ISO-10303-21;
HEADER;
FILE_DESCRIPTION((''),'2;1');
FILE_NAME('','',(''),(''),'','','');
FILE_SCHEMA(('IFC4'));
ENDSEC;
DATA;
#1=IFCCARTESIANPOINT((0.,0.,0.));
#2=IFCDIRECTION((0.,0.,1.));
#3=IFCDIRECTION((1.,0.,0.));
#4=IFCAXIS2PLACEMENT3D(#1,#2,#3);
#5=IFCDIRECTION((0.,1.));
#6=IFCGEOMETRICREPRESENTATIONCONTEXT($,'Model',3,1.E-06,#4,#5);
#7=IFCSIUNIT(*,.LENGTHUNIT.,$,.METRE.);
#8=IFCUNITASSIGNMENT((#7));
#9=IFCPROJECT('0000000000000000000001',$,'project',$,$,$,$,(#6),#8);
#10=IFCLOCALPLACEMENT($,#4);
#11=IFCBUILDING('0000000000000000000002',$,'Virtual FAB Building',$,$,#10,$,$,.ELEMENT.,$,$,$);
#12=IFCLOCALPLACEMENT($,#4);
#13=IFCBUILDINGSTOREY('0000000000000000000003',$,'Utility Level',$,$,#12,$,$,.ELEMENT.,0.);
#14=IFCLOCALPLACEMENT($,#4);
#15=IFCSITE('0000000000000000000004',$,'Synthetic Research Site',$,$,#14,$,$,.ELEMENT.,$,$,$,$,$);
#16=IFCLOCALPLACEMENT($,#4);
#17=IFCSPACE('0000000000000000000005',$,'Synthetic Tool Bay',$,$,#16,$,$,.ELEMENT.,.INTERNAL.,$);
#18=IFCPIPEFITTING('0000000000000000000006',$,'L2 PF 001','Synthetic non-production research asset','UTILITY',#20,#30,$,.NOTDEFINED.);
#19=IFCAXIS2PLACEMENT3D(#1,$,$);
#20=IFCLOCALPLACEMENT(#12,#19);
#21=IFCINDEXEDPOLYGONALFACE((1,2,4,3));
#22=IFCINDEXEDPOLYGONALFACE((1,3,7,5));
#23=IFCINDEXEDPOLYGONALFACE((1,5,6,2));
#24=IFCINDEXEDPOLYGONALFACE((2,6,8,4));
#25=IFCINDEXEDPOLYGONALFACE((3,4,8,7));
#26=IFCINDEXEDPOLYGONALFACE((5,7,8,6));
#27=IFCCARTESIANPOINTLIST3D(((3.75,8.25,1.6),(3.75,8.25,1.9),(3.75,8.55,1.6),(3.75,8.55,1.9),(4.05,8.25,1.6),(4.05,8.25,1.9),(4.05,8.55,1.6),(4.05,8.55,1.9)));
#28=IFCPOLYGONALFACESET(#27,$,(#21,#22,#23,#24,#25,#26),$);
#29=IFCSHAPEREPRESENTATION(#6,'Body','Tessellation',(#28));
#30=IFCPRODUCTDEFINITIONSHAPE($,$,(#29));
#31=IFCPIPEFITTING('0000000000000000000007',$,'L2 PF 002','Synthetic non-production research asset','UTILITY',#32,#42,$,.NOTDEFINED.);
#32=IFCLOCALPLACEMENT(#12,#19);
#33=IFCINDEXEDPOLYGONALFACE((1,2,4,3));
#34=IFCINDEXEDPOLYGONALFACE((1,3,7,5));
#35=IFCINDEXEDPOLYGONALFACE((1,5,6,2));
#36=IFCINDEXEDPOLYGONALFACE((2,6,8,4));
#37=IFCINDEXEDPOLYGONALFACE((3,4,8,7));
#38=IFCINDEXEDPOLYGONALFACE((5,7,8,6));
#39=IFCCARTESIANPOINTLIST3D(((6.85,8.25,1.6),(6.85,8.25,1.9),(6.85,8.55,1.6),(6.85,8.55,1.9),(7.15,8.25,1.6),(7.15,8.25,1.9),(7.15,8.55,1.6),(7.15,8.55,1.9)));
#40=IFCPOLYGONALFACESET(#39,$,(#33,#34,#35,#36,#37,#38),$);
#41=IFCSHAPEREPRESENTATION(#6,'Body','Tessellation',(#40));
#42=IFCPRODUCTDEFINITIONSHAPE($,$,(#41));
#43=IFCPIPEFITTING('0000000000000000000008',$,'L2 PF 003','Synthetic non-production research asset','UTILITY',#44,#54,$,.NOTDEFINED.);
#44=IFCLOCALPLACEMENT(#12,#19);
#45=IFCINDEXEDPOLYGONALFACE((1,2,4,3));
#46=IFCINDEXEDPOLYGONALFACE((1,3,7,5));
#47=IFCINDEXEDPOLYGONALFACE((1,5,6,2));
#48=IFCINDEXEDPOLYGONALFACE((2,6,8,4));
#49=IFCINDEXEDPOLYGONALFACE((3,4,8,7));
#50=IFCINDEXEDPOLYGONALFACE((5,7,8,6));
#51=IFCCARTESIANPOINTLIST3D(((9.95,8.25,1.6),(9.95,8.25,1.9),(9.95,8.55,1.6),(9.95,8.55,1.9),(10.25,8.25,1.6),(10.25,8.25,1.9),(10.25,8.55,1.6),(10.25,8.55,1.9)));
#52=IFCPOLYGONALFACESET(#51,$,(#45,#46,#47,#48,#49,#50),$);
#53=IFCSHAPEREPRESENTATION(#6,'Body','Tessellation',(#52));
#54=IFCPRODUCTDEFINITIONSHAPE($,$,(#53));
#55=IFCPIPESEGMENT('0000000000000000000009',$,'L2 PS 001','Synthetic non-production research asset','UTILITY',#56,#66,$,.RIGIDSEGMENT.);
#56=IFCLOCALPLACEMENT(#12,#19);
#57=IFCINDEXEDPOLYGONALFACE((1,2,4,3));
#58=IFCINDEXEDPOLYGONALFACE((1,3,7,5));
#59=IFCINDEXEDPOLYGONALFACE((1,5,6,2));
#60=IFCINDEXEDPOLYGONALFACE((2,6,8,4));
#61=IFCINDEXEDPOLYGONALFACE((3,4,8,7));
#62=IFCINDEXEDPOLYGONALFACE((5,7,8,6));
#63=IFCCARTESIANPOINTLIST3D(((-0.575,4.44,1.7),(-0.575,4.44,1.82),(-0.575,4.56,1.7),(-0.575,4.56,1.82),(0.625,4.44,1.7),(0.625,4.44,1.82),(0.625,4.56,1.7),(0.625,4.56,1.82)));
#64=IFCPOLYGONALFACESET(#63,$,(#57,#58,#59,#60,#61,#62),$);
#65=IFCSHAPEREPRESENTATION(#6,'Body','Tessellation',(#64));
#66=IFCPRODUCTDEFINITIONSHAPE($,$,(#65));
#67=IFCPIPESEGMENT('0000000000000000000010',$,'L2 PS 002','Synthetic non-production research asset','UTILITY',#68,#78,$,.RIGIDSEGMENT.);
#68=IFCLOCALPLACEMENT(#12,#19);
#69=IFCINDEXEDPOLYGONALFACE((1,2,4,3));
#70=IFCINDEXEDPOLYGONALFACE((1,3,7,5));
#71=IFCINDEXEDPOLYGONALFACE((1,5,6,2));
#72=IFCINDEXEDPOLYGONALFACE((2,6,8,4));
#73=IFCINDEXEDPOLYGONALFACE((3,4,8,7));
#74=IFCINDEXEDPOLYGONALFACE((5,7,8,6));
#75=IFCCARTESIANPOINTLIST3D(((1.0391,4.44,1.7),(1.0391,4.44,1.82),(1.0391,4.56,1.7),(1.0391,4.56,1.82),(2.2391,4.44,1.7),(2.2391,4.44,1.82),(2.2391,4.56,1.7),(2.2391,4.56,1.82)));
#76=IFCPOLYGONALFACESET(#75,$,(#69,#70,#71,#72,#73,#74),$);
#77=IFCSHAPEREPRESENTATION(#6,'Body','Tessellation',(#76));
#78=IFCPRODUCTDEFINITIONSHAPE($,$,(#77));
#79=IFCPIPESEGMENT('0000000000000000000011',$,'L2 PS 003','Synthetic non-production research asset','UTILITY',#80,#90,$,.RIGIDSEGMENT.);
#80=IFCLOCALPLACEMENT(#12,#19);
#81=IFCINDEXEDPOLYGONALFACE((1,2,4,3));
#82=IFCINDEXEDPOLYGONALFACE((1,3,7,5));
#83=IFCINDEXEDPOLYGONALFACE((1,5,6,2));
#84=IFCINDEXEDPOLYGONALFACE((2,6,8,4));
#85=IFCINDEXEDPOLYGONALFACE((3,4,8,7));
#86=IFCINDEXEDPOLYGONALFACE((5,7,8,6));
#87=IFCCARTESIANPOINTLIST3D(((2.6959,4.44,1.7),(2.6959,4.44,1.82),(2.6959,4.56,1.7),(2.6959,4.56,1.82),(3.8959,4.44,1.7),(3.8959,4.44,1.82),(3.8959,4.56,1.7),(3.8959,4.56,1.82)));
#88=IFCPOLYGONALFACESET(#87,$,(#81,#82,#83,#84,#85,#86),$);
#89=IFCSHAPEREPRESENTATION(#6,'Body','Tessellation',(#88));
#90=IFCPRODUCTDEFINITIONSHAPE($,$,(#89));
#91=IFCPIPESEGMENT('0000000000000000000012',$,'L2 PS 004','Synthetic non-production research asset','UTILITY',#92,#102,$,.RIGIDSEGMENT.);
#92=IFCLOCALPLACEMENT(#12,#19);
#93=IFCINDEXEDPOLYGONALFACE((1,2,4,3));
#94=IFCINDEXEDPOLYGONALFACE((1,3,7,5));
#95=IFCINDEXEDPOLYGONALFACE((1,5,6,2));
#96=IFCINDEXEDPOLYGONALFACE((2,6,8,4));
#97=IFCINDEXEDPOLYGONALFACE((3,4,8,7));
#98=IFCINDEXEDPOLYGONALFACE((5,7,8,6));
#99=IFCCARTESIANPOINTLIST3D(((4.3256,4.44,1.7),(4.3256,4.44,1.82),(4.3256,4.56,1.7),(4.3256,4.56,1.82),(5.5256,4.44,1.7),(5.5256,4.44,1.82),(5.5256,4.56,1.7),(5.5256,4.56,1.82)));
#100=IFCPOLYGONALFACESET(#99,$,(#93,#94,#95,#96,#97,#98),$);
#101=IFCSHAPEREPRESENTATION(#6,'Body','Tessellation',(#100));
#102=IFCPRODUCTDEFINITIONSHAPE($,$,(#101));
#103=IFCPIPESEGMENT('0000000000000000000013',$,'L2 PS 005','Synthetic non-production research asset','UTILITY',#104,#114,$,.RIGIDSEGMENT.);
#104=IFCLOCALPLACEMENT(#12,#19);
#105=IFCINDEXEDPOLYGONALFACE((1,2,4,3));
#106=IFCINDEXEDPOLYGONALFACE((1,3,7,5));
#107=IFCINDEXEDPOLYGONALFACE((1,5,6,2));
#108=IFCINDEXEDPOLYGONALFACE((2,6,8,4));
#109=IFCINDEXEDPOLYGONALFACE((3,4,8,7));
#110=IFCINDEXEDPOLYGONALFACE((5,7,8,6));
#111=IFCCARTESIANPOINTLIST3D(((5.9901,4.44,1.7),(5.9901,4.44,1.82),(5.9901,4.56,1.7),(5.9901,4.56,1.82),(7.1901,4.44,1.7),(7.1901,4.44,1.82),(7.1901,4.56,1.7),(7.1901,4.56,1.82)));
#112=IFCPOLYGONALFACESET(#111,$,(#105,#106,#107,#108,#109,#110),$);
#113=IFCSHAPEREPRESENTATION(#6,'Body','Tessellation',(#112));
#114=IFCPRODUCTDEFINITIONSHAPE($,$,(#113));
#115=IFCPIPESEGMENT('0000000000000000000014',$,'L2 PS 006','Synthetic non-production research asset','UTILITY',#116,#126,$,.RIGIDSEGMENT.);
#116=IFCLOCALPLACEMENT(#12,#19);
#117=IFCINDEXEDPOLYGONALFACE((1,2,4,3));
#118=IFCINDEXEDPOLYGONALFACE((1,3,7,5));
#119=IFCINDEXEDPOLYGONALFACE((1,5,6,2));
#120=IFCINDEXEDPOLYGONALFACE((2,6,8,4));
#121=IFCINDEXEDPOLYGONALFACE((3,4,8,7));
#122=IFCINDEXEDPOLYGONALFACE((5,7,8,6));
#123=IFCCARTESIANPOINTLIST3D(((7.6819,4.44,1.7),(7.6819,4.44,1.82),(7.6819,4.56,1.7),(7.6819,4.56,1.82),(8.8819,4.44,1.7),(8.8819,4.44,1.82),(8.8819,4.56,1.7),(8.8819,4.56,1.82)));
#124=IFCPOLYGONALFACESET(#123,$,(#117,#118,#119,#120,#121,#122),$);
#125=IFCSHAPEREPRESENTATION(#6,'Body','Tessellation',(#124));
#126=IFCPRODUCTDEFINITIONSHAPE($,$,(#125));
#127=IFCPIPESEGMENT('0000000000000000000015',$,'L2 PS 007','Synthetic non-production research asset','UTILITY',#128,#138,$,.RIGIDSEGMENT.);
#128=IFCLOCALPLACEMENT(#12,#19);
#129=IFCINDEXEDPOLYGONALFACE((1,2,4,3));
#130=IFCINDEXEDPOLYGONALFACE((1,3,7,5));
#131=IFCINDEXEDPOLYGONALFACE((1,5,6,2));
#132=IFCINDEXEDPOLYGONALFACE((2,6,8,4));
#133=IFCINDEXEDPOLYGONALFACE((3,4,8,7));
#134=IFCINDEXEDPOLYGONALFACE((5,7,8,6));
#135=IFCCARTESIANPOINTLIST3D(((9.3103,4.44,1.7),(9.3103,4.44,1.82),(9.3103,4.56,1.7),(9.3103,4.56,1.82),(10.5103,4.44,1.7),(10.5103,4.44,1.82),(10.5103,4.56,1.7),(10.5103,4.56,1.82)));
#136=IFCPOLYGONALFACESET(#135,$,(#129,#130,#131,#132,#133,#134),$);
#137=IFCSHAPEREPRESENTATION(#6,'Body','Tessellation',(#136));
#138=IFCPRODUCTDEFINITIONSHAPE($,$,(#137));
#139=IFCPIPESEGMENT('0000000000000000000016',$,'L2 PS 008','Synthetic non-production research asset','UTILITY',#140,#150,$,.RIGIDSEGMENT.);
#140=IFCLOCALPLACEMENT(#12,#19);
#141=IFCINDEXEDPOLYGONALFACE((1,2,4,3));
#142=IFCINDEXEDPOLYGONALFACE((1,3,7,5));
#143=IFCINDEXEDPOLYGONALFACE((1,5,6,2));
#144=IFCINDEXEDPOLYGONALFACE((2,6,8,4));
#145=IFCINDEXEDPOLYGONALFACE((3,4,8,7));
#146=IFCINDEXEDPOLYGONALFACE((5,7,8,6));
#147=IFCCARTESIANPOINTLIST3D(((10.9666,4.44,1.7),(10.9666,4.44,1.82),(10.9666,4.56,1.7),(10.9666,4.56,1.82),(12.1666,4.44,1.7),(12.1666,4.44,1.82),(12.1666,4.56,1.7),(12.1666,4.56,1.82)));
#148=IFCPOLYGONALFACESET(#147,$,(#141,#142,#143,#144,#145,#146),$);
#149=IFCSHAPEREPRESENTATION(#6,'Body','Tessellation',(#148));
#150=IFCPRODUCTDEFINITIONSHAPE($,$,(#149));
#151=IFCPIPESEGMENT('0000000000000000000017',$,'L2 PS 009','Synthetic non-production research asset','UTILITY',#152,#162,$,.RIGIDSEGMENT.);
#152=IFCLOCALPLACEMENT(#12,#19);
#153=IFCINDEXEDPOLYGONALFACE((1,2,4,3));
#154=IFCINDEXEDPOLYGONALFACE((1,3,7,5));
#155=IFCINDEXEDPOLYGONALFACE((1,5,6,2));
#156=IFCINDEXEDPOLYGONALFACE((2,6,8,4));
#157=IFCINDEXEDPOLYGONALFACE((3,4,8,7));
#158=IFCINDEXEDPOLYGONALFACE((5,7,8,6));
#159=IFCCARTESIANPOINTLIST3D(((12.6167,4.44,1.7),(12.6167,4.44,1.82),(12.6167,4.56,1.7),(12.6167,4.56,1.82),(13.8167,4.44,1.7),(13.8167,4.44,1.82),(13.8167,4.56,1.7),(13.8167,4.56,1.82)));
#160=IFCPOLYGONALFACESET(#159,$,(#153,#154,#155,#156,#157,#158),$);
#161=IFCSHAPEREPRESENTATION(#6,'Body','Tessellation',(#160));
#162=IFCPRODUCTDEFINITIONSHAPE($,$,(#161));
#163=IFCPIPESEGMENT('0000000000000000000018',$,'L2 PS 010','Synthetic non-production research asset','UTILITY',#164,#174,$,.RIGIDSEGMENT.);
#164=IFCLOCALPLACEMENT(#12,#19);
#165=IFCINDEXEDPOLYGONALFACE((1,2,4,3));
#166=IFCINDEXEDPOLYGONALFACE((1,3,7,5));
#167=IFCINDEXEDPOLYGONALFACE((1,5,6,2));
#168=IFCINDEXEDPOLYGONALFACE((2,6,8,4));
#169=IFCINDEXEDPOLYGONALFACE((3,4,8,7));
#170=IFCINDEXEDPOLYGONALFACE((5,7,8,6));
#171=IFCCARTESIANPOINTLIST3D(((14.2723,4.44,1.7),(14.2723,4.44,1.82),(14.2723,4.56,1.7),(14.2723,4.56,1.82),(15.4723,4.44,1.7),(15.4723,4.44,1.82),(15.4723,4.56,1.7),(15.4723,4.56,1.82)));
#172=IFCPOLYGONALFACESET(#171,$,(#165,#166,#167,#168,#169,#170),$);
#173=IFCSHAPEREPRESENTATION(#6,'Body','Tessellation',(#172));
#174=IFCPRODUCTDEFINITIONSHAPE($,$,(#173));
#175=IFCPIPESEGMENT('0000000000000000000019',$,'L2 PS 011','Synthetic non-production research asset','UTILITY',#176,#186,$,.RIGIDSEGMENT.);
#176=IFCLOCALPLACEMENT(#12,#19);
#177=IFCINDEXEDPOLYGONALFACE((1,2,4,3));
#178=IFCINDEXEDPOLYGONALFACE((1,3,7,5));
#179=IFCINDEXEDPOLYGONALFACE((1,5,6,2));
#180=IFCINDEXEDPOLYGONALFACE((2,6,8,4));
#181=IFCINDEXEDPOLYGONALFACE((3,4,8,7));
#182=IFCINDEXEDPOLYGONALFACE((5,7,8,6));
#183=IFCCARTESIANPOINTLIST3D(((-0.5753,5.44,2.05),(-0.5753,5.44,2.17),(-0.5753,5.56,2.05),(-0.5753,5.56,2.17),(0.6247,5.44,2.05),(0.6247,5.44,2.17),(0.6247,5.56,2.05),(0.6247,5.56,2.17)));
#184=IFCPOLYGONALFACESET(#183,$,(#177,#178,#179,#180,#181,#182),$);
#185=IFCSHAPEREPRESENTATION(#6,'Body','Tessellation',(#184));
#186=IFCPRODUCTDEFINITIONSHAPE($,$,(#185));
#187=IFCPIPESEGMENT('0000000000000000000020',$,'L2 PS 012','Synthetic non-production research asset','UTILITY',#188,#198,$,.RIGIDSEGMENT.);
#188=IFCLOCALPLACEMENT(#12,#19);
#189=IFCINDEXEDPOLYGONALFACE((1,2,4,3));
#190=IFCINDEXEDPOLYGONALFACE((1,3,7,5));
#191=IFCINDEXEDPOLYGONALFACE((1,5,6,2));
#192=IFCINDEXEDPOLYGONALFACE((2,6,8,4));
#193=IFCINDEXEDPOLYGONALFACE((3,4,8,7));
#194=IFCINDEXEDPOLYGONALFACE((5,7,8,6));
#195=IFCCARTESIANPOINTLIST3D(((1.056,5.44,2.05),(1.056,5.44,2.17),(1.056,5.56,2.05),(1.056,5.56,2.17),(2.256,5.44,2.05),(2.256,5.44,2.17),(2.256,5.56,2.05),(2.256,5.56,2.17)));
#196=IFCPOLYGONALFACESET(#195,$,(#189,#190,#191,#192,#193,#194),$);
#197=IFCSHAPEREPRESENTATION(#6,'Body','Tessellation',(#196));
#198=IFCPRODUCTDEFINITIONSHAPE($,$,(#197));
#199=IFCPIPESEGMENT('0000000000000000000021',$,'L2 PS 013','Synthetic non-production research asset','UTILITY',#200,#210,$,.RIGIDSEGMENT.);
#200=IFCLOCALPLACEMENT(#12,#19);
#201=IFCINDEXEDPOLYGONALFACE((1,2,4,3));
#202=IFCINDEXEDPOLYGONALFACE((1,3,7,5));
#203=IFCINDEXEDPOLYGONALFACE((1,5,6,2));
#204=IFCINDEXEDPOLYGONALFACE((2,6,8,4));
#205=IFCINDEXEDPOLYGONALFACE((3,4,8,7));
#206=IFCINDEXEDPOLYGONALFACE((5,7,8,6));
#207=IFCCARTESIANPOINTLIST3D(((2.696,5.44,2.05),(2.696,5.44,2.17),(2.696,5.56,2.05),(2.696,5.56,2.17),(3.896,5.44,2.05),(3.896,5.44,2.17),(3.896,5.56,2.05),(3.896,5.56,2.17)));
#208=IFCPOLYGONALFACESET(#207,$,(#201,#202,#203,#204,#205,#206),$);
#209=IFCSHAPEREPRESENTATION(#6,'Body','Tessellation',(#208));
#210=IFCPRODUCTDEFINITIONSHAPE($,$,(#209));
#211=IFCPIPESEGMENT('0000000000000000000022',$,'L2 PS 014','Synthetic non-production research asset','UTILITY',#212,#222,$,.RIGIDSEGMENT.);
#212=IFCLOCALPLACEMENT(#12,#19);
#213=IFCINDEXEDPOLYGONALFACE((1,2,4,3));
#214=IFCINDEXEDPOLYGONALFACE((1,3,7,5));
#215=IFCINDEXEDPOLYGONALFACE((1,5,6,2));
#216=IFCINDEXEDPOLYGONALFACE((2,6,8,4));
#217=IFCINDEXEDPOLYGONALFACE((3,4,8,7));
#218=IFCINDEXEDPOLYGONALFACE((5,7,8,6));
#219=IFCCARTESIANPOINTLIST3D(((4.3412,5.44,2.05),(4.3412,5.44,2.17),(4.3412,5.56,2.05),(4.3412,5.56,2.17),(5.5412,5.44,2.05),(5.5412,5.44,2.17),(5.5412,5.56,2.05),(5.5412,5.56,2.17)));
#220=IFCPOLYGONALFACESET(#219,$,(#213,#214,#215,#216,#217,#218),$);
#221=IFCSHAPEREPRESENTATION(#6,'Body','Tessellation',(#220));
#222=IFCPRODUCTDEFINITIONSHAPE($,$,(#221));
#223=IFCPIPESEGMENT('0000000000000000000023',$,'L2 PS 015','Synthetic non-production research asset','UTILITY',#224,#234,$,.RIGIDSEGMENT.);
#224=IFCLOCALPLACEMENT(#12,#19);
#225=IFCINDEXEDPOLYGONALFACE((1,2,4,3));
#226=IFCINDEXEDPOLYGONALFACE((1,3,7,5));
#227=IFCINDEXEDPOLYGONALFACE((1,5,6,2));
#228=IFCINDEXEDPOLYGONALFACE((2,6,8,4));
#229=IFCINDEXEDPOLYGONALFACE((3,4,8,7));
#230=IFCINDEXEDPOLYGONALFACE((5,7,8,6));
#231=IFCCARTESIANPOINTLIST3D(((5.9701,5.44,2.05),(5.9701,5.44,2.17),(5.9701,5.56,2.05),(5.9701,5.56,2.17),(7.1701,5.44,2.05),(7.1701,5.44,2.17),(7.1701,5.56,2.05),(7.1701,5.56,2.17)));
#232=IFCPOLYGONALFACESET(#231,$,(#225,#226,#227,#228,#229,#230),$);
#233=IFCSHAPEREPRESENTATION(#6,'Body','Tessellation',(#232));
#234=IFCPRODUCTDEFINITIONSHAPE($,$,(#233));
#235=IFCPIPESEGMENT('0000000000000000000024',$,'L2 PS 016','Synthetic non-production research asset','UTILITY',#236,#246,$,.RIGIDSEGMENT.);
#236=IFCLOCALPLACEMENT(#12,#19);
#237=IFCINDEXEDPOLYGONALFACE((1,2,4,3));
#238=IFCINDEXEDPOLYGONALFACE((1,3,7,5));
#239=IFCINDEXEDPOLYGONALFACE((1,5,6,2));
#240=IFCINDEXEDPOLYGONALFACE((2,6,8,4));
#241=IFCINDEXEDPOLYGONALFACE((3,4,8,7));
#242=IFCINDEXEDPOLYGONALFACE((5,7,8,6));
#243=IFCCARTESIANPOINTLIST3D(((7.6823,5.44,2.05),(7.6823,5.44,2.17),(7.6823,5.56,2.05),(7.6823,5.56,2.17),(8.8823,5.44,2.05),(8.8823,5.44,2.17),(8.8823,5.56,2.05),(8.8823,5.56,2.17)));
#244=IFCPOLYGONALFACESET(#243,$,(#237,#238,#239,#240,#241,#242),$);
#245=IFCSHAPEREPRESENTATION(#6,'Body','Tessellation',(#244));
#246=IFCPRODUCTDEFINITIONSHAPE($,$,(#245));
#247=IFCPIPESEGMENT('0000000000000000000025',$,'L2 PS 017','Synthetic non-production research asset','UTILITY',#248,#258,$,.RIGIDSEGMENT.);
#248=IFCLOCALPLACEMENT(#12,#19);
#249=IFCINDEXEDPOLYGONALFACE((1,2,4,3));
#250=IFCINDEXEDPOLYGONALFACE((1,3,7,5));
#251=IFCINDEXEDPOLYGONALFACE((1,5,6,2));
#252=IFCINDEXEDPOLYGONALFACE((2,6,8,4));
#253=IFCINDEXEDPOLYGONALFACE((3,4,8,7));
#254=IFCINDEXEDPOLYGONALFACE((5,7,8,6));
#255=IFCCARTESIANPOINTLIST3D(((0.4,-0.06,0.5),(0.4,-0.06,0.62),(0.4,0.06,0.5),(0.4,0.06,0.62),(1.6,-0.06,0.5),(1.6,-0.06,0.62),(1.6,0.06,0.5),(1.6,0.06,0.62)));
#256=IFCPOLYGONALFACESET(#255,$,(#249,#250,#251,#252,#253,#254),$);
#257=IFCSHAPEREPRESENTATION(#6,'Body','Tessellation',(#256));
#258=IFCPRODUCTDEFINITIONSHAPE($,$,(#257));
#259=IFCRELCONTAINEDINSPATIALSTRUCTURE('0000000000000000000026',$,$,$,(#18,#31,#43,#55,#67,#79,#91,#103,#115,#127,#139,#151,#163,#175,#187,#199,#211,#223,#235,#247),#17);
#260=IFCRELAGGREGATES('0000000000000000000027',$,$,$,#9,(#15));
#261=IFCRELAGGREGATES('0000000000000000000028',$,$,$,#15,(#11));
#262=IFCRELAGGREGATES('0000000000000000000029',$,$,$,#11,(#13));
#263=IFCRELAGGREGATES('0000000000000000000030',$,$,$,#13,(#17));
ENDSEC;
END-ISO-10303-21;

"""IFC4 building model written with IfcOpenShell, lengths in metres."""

from ifc_helpers import new_model, si_unit, direction, frame, origin_with_axes, origin_2d_with_axis, place, context, project, spatial, rectangle, extrude, element, save


model = new_model("IFC4")

# Units and contexts
model_context = context("Model", 3, precision=1e-06, world=origin_with_axes(), true_north=direction((0.0, 1.0)))
ifc_project = project(units=[si_unit("LENGTHUNIT", "METRE")], contexts=[model_context])

# Site, building, storey, space
site_placement = place(None, origin_with_axes())
site = spatial("IfcSite", under=ifc_project, at=site_placement, Name="Synthetic Research Site", CompositionType="ELEMENT")
building_placement = place(None, origin_with_axes())
building = spatial("IfcBuilding", under=site, at=building_placement, Name="Virtual FAB Building", CompositionType="ELEMENT")
storey_placement = place(None, origin_with_axes())
storey = spatial("IfcBuildingStorey", under=building, at=storey_placement, Name="Utility Level", CompositionType="ELEMENT", Elevation=0.0)
space_placement = place(None, origin_with_axes())
space = spatial("IfcSpace", under=storey, at=space_placement, Name="Synthetic Tool Bay", CompositionType="ELEMENT", PredefinedType="INTERNAL")

# Pipe fittings
for number, where, z_axis, x_axis, name in (
    (1, (3.9, 8.4, 1.6), (0.0, 0.0, 1.0), (1.0, 0.0, 0.0), "L2 PF 001"),
    (2, (7.0, 8.4, 1.6), (0.0, 0.0, 1.0), (1.0, 0.0, 0.0), "L2 PF 002"),
    (3, (10.1, 8.4, 1.6), (0.0, 0.0, 1.0), (1.0, 0.0, 0.0), "L2 PF 003"),
):
    element("IfcPipeFitting", number, at=place(None, frame(where, z_axis=z_axis, x_axis=x_axis)), inside=space, Name=name, Description="Synthetic non-production research asset", ObjectType="UTILITY", PredefinedType="NOTDEFINED", context=model_context, shape_type="SweptSolid", body=[
        extrude(rectangle(XDim=0.3, YDim=0.3, at=origin_2d_with_axis()), origin_with_axes(), (0.0, 0.0, 1.0), 0.3),
    ])

# Pipe segments
for number, where, z_axis, x_axis, name in (
    (4, (0.025, 4.5, 1.7), (0.0, 0.0, 1.0), (1.0, 0.0, 0.0), "L2 PS 001"),
    (5, (1.6391, 4.5, 1.7), (0.0, 0.0, 1.0), (1.0, 0.0, 0.0), "L2 PS 002"),
    (6, (3.2959, 4.5, 1.7), (0.0, 0.0, 1.0), (1.0, 0.0, 0.0), "L2 PS 003"),
    (7, (4.9256, 4.5, 1.7), (0.0, 0.0, 1.0), (1.0, 0.0, 0.0), "L2 PS 004"),
    (8, (6.5901, 4.5, 1.7), (0.0, 0.0, 1.0), (1.0, 0.0, 0.0), "L2 PS 005"),
    (9, (8.2819, 4.5, 1.7), (0.0, 0.0, 1.0), (1.0, 0.0, 0.0), "L2 PS 006"),
    (10, (9.9103, 4.5, 1.7), (0.0, 0.0, 1.0), (1.0, 0.0, 0.0), "L2 PS 007"),
    (11, (11.5666, 4.5, 1.7), (0.0, 0.0, 1.0), (1.0, 0.0, 0.0), "L2 PS 008"),
    (12, (13.2167, 4.5, 1.7), (0.0, 0.0, 1.0), (1.0, 0.0, 0.0), "L2 PS 009"),
    (13, (14.8723, 4.5, 1.7), (0.0, 0.0, 1.0), (1.0, 0.0, 0.0), "L2 PS 010"),
    (14, (0.0247, 5.5, 2.05), (0.0, 0.0, 1.0), (1.0, 0.0, 0.0), "L2 PS 011"),
    (15, (1.656, 5.5, 2.05), (0.0, 0.0, 1.0), (1.0, 0.0, 0.0), "L2 PS 012"),
    (16, (3.296, 5.5, 2.05), (0.0, 0.0, 1.0), (1.0, 0.0, 0.0), "L2 PS 013"),
    (17, (4.9412, 5.5, 2.05), (0.0, 0.0, 1.0), (1.0, 0.0, 0.0), "L2 PS 014"),
    (18, (6.5701, 5.5, 2.05), (0.0, 0.0, 1.0), (1.0, 0.0, 0.0), "L2 PS 015"),
    (19, (8.2823, 5.5, 2.05), (0.0, 0.0, 1.0), (1.0, 0.0, 0.0), "L2 PS 016"),
    (20, (1.0, 0.0, 0.5), (0.0, 0.0, 1.0), (1.0, 0.0, 0.0), "L2 PS 017"),
):
    element("IfcPipeSegment", number, at=place(None, frame(where, z_axis=z_axis, x_axis=x_axis)), inside=space, Name=name, Description="Synthetic non-production research asset", ObjectType="UTILITY", PredefinedType="RIGIDSEGMENT", context=model_context, shape_type="SweptSolid", body=[
        extrude(rectangle(XDim=1.2, YDim=0.12, at=origin_2d_with_axis()), origin_with_axes(), (0.0, 0.0, 1.0), 0.12),
    ])

save(model, "model.ifc")
